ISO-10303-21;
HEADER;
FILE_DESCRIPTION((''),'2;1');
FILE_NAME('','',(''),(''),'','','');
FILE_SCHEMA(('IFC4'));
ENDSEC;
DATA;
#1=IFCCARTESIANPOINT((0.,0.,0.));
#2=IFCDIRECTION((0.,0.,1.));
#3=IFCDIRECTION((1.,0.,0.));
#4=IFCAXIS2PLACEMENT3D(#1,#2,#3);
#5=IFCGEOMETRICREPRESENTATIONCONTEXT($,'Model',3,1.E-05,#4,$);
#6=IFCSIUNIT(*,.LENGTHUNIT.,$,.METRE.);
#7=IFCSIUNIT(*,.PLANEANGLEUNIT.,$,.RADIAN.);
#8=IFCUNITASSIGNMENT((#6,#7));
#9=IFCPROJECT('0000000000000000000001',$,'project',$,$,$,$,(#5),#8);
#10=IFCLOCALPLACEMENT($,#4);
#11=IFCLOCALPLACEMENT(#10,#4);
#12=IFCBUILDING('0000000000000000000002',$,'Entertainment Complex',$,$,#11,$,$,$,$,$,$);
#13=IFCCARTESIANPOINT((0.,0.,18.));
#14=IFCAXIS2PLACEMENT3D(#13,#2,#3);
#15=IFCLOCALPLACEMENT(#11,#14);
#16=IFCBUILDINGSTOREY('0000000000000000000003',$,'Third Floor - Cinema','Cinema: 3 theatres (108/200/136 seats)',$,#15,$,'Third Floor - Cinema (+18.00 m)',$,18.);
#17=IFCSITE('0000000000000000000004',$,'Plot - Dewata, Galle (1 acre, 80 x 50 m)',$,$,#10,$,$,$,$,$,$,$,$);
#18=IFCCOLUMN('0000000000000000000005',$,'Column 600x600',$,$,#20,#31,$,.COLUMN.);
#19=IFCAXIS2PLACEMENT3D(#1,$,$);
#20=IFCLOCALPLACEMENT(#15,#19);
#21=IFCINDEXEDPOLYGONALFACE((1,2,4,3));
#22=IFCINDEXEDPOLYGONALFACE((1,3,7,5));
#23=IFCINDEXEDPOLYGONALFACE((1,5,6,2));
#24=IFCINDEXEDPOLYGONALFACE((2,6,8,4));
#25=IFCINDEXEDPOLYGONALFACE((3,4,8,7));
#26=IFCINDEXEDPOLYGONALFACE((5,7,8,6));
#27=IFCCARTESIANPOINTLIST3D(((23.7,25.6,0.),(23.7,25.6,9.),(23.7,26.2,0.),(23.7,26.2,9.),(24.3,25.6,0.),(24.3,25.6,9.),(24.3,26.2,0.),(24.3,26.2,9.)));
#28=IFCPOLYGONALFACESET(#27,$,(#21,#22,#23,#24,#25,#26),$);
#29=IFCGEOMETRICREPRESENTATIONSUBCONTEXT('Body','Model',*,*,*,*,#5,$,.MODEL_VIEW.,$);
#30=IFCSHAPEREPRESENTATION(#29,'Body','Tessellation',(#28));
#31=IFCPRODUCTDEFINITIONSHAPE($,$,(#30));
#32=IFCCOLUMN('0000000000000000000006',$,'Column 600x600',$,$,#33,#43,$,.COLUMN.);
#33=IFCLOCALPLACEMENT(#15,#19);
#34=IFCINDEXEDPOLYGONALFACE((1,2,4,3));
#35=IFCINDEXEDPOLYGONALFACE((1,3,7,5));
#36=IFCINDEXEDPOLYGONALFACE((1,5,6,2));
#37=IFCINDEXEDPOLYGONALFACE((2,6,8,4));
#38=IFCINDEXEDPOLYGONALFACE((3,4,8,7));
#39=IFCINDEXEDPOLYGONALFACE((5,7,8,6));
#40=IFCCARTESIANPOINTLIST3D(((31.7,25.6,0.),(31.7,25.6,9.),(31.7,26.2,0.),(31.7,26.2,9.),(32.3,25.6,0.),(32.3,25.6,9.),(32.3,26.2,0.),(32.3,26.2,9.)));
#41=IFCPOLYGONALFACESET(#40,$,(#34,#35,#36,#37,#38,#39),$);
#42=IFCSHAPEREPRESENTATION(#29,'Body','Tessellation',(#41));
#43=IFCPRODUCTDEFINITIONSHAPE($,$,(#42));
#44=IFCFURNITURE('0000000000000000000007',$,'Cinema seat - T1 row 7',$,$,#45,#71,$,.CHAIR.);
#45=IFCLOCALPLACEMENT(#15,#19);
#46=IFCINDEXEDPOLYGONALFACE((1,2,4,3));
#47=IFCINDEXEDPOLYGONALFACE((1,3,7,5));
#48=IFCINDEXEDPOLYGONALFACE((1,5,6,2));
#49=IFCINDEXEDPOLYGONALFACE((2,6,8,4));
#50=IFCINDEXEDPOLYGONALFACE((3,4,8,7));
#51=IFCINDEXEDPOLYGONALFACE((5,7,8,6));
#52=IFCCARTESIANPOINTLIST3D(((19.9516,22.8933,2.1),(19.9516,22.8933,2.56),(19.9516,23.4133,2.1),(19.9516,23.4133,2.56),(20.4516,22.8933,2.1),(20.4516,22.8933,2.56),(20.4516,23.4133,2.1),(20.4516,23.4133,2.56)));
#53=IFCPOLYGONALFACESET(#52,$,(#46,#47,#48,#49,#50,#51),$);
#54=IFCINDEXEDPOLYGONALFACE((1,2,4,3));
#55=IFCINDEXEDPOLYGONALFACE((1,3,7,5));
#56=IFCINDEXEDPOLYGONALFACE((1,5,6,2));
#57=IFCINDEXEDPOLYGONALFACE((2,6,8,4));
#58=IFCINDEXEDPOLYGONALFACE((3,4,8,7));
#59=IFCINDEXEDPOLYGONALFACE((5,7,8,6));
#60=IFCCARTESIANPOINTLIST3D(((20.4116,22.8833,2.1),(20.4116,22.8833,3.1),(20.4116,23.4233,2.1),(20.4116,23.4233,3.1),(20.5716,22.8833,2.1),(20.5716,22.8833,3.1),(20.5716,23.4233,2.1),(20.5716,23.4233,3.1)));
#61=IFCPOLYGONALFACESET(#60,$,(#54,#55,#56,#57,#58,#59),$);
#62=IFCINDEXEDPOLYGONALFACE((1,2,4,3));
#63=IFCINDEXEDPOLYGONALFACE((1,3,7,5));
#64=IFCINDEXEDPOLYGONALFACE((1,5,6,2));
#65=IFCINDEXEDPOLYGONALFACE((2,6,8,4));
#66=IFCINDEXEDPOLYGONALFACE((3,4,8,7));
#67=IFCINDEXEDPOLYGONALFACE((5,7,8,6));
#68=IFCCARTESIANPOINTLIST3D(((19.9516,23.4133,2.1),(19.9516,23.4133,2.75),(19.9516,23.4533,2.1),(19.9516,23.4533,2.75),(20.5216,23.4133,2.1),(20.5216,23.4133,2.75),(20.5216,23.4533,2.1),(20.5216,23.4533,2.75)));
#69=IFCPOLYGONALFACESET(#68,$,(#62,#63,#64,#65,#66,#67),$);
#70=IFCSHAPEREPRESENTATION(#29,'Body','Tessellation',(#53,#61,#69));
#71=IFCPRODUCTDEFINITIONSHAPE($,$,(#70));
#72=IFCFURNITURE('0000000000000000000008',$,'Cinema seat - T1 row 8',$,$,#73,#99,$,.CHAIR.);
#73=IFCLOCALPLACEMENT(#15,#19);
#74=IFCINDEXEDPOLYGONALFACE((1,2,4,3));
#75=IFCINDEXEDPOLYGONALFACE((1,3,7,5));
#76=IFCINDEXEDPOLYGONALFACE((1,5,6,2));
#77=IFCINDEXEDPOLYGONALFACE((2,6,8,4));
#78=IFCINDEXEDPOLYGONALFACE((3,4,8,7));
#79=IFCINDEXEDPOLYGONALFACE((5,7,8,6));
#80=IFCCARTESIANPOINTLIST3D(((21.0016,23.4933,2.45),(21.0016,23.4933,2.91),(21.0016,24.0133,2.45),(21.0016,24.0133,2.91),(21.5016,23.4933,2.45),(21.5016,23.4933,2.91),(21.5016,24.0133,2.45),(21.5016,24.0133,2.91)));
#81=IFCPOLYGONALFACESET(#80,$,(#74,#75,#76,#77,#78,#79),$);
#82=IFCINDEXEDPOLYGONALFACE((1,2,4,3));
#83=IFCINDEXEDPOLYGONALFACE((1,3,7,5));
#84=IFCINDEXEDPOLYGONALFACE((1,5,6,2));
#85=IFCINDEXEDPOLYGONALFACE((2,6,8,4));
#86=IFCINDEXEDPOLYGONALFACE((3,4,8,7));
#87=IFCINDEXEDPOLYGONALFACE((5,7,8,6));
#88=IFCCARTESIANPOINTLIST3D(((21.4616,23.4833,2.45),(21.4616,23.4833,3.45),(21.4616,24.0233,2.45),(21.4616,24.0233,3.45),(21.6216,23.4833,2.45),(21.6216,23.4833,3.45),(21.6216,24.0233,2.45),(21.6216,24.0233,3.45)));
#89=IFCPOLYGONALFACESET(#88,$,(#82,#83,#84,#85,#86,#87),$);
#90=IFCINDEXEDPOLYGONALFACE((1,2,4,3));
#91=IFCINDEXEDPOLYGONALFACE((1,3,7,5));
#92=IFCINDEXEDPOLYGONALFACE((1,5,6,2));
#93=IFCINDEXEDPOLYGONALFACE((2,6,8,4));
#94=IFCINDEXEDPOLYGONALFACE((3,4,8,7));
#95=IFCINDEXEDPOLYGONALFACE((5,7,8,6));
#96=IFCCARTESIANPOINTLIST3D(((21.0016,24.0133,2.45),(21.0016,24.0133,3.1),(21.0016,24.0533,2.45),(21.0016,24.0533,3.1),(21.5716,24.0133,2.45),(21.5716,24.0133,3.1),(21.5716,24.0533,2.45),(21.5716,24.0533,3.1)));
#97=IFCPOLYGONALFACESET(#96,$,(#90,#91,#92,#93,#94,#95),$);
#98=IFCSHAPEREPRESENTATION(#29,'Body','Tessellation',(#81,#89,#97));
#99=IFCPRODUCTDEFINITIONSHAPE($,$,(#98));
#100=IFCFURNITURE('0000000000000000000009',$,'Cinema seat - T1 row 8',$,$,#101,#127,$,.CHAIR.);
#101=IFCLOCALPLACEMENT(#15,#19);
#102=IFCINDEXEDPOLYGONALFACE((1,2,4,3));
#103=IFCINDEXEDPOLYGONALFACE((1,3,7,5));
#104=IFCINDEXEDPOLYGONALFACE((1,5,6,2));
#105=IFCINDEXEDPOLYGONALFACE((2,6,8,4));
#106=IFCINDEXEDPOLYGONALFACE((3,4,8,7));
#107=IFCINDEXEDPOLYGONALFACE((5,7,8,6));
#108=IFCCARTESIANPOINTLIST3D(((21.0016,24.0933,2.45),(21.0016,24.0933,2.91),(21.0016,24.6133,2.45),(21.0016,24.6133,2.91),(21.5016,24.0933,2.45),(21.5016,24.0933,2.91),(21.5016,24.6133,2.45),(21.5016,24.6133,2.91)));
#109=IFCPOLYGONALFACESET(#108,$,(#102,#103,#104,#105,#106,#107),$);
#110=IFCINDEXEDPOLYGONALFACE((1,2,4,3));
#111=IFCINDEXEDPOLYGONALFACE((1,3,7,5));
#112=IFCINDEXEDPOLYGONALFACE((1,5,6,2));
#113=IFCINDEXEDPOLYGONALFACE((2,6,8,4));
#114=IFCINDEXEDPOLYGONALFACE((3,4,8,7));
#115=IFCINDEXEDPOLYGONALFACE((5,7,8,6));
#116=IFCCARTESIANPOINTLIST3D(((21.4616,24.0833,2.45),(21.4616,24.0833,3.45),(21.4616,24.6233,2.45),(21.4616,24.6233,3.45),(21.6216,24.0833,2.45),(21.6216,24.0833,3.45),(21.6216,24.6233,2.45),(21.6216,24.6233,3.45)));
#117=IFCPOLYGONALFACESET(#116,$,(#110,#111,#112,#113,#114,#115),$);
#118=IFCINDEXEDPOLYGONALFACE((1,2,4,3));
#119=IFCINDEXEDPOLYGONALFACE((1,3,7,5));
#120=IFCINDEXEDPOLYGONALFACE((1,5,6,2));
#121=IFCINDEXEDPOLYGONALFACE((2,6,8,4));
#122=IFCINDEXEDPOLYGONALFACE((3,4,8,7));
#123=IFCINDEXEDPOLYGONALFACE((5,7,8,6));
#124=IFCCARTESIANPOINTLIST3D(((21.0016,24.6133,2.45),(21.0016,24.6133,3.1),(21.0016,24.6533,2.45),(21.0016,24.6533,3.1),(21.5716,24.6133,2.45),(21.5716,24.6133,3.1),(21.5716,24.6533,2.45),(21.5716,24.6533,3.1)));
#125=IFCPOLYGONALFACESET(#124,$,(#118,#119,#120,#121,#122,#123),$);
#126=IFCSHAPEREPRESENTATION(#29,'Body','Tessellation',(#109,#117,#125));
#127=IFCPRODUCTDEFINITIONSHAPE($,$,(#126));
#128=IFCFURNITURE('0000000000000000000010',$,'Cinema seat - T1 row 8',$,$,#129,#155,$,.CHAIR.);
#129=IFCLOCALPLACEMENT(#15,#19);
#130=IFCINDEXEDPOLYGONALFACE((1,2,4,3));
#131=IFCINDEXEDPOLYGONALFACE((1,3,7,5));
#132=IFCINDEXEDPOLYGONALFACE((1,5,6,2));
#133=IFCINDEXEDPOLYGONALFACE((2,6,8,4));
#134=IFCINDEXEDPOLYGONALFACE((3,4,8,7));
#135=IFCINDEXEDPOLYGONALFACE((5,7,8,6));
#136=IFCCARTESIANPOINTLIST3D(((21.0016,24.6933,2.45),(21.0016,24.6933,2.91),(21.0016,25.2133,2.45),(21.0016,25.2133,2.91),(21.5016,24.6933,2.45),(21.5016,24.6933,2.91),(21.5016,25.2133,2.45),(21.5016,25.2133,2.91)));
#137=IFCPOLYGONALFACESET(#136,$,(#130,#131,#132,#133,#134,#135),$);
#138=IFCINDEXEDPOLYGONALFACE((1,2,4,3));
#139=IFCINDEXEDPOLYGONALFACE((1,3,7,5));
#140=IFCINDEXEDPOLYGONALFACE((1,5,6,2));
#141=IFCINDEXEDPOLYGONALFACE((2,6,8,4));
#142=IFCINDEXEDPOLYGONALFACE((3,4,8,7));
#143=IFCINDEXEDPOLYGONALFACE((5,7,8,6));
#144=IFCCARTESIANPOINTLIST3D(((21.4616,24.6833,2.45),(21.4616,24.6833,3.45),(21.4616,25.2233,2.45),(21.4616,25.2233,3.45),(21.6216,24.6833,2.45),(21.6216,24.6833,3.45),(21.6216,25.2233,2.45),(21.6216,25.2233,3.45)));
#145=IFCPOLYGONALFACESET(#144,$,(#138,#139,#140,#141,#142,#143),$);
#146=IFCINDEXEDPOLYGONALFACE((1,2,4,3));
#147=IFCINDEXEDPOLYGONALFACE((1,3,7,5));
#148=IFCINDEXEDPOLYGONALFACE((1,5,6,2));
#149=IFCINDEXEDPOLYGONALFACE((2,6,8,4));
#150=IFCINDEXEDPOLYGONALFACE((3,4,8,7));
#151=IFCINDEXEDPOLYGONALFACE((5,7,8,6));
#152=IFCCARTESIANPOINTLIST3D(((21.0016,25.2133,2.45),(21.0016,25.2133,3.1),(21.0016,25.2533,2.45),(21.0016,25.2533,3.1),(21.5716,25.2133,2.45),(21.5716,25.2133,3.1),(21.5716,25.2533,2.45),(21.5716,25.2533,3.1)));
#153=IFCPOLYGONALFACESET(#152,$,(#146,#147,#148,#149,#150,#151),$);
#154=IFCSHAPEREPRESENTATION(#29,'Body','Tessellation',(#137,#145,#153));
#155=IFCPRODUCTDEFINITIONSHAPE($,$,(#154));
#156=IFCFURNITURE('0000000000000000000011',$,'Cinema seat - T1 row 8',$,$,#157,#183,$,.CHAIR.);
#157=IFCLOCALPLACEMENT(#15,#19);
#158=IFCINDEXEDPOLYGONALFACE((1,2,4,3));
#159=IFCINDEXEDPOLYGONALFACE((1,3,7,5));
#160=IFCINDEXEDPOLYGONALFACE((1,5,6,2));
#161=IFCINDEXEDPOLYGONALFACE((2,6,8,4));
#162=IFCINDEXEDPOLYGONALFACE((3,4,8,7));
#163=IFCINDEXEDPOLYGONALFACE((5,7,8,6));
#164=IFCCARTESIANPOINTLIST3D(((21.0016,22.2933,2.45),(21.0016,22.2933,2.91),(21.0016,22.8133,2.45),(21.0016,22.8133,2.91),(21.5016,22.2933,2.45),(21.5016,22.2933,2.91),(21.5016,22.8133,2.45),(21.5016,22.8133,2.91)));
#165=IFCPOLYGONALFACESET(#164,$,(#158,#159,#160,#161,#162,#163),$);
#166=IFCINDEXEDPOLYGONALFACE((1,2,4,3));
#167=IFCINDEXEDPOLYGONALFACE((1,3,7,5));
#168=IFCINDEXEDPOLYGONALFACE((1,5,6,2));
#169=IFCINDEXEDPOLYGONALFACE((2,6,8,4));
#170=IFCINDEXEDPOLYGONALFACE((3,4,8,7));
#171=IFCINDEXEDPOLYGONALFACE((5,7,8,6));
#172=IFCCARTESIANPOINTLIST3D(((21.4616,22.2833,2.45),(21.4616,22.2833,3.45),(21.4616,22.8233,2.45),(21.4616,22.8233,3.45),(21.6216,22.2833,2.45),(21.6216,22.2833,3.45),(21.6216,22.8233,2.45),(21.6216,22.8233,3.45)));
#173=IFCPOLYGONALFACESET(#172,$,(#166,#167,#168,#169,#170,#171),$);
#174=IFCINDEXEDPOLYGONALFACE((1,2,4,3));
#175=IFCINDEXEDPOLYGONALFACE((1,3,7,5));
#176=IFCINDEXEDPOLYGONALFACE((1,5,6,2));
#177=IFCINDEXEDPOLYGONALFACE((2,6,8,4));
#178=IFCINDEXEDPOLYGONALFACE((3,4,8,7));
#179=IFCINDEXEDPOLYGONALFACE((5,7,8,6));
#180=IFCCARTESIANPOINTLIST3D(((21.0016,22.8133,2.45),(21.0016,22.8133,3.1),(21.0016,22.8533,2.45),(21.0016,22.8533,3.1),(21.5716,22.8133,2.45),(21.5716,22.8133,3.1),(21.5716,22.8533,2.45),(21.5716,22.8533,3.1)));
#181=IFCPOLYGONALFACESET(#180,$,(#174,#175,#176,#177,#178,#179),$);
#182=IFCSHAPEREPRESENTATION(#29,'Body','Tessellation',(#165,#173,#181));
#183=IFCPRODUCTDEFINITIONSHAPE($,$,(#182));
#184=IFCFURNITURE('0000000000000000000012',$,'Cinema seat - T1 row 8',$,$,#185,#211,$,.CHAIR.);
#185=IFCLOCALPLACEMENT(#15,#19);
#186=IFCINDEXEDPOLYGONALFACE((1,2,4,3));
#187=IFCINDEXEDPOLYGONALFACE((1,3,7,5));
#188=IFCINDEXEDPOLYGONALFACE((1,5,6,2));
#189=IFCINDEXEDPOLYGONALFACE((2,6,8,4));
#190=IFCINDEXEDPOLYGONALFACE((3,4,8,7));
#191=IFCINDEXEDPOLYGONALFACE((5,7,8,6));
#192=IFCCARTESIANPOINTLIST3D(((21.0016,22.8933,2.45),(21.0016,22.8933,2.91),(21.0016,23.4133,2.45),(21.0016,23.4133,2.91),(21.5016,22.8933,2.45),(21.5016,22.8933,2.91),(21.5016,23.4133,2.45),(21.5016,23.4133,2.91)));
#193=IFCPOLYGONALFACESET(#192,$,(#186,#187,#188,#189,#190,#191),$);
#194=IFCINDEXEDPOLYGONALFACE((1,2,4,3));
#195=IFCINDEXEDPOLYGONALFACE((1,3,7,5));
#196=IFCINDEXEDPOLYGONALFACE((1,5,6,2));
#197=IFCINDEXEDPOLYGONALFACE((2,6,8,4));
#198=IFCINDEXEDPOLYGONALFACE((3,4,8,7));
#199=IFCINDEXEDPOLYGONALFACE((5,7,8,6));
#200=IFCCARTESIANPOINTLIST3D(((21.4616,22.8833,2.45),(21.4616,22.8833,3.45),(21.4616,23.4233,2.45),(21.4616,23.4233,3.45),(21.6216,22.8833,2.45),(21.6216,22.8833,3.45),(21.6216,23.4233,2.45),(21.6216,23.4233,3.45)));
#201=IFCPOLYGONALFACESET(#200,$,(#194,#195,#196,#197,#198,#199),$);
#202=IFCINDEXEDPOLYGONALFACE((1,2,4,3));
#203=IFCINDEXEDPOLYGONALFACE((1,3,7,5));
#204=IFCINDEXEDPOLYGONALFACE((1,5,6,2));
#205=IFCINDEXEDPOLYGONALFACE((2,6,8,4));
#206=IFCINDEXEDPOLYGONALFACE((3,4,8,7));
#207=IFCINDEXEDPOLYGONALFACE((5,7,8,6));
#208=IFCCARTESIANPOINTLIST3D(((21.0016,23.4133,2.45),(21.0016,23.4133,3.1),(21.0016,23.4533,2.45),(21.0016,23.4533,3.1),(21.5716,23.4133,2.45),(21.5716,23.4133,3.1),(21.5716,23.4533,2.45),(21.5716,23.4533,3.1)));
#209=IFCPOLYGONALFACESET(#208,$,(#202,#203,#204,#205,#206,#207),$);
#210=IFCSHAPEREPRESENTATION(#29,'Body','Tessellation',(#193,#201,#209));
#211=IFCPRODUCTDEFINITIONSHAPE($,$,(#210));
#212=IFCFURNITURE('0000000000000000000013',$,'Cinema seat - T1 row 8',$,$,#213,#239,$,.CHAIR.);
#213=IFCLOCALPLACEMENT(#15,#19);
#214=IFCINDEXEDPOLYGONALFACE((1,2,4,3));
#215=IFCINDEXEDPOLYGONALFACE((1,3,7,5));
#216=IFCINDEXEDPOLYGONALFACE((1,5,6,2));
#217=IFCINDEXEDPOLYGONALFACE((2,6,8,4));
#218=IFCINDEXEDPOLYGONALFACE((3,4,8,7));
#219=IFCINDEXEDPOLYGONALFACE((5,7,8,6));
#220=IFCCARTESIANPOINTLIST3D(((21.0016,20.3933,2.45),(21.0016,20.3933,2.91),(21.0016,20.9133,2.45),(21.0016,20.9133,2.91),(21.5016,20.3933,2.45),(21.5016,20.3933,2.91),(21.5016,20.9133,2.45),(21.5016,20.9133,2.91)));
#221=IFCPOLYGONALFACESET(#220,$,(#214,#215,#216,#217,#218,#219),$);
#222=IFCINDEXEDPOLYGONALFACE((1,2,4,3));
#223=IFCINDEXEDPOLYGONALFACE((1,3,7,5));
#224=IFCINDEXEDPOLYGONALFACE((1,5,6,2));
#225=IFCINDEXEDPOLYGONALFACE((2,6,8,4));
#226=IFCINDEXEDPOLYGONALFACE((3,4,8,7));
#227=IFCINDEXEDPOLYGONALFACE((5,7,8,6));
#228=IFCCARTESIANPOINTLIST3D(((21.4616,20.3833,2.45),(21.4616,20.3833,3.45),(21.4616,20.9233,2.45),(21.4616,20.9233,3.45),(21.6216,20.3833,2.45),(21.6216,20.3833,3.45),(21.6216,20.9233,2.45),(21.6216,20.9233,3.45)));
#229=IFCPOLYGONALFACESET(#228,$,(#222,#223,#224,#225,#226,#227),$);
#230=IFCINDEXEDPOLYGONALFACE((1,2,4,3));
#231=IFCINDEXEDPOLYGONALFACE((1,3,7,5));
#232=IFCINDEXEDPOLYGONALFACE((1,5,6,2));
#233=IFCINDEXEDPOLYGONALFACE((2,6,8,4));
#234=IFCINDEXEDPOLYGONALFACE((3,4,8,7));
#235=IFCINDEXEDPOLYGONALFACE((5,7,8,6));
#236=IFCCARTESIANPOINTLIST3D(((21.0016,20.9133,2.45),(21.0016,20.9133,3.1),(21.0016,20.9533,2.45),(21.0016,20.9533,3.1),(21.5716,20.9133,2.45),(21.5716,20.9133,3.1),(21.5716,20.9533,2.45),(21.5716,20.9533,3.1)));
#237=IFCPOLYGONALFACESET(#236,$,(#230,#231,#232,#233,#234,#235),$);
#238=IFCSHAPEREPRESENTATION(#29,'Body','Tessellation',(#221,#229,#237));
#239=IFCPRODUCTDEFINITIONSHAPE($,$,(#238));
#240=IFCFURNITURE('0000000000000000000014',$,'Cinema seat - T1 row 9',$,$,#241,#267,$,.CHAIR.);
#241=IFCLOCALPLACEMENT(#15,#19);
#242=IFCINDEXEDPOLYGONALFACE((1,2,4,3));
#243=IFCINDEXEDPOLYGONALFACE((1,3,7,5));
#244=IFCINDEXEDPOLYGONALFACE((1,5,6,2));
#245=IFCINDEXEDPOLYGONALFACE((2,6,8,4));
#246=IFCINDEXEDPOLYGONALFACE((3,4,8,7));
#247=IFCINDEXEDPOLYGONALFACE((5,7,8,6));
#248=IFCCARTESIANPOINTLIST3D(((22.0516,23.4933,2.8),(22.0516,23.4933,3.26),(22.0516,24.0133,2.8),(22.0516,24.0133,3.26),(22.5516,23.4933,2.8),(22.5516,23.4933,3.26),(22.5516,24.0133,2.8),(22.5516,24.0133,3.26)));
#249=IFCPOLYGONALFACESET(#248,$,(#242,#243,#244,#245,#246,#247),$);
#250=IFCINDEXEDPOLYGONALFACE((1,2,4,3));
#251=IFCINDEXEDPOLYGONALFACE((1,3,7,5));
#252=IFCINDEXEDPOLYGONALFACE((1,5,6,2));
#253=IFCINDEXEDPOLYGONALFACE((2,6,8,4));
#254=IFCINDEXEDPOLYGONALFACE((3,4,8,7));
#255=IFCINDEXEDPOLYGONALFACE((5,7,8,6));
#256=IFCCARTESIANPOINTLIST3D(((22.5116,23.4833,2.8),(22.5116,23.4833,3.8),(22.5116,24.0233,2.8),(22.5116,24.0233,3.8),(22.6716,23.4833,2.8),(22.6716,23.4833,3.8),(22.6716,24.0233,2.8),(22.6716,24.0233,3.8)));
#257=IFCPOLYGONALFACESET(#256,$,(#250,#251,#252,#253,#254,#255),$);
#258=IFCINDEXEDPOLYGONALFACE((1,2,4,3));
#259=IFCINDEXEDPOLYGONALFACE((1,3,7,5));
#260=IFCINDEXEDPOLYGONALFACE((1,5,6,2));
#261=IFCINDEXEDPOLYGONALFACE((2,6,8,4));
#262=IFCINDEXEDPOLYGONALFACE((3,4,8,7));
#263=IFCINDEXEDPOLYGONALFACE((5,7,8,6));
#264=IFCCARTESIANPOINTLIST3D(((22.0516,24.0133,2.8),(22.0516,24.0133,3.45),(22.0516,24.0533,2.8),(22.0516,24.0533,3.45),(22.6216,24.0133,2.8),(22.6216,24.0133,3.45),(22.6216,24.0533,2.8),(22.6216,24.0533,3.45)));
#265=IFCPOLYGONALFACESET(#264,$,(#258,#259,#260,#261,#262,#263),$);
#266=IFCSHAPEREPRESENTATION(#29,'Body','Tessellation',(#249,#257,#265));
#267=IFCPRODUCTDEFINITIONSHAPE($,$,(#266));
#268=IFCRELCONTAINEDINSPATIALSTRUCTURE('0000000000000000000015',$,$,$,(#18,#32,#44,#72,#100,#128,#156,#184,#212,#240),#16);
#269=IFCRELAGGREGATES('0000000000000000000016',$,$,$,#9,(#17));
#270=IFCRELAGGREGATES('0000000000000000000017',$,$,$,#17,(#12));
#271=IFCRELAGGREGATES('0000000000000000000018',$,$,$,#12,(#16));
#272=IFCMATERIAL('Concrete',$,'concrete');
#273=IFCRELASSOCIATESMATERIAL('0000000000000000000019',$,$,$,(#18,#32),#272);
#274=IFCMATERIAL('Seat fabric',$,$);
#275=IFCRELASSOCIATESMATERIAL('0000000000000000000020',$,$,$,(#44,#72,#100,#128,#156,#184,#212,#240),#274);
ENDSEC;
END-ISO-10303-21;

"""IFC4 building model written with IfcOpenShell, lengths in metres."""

from ifc_helpers import new_model, si_unit, frame, origin_with_axes, place, context, subcontext, project, spatial, polyline, outline, extrude, material, element, save


model = new_model("IFC4")

# Units and contexts
model_context = context("Model", 3, precision=1e-05, world=origin_with_axes())
body_context = subcontext(model_context, "Body", "Model", "MODEL_VIEW")
ifc_project = project(units=[si_unit("LENGTHUNIT", "METRE"), si_unit("PLANEANGLEUNIT", "RADIAN")], contexts=[model_context])

# Site, building, storey
site_placement = place(None, origin_with_axes())
site = spatial("IfcSite", under=ifc_project, at=site_placement, Name="Plot - Dewata, Galle (1 acre, 80 x 50 m)")
building_placement = place(site_placement, origin_with_axes())
building = spatial("IfcBuilding", under=site, at=building_placement, Name="Entertainment Complex")
storey_placement = place(building_placement, frame((0.0, 0.0, 18.0), z_axis=(0.0, 0.0, 1.0), x_axis=(1.0, 0.0, 0.0)))
storey = spatial("IfcBuildingStorey", under=building, at=storey_placement, Name="Third Floor - Cinema", Description="Cinema: 3 theatres (108/200/136 seats)", LongName="Third Floor - Cinema (+18.00 m)", Elevation=18.0)

# Columns
ifc_material_1 = material(Name="Concrete", Category="concrete")
for number, where, z_axis, x_axis, name in (
    (1, (24.0, 25.9, 0.0), (0.0, 0.0, 1.0), (1.0, 0.0, 0.0), "Column 600x600"),
    (2, (32.0, 25.9, 0.0), (0.0, 0.0, 1.0), (1.0, 0.0, 0.0), "Column 600x600"),
):
    element("IfcColumn", number, at=place(storey_placement, frame(where, z_axis=z_axis, x_axis=x_axis)), inside=storey, material=ifc_material_1, Name=name, PredefinedType="COLUMN", context=body_context, shape_type="SweptSolid", body=[
        extrude(outline(polyline([(-0.3, -0.3), (0.3, -0.3), (0.3, 0.3), (-0.3, 0.3), (-0.3, -0.3)])), origin_with_axes(), (0.0, 0.0, 1.0), 9.0),
    ])

# Furniture
ifc_material_2 = material(Name="Seat fabric")
for number, where, z_axis, x_axis, name in (
    (3, (20.5716, 23.1533, 2.1), (0.0, 0.0, 1.0), (1.0, 0.0, 0.0), "Cinema seat - T1 row 7"),
    (4, (21.6216, 23.7533, 2.45), (0.0, 0.0, 1.0), (1.0, 0.0, 0.0), "Cinema seat - T1 row 8"),
    (5, (21.6216, 24.3533, 2.45), (0.0, 0.0, 1.0), (1.0, 0.0, 0.0), "Cinema seat - T1 row 8"),
    (6, (21.6216, 24.9533, 2.45), (0.0, 0.0, 1.0), (1.0, 0.0, 0.0), "Cinema seat - T1 row 8"),
    (7, (21.6216, 22.5533, 2.45), (0.0, 0.0, 1.0), (1.0, 0.0, 0.0), "Cinema seat - T1 row 8"),
    (8, (21.6216, 23.1533, 2.45), (0.0, 0.0, 1.0), (1.0, 0.0, 0.0), "Cinema seat - T1 row 8"),
    (9, (21.6216, 20.6533, 2.45), (0.0, 0.0, 1.0), (1.0, 0.0, 0.0), "Cinema seat - T1 row 8"),
    (10, (22.6716, 23.7533, 2.8), (0.0, 0.0, 1.0), (1.0, 0.0, 0.0), "Cinema seat - T1 row 9"),
):
    element("IfcFurniture", number, at=place(storey_placement, frame(where, z_axis=z_axis, x_axis=x_axis)), inside=storey, material=ifc_material_2, Name=name, PredefinedType="CHAIR", context=body_context, shape_type="SweptSolid", body=[
        extrude(outline(polyline([(-0.62, -0.26), (-0.12, -0.26), (-0.12, 0.26), (-0.62, 0.26), (-0.62, -0.26)])), origin_with_axes(), (0.0, 0.0, 1.0), 0.46),
        extrude(outline(polyline([(-0.16, -0.27), (0.0, -0.27), (0.0, 0.27), (-0.16, 0.27), (-0.16, -0.27)])), origin_with_axes(), (0.0, 0.0, 1.0), 1.0),
        extrude(outline(polyline([(-0.62, 0.26), (-0.05, 0.26), (-0.05, 0.3), (-0.62, 0.3), (-0.62, 0.26)])), origin_with_axes(), (0.0, 0.0, 1.0), 0.65),
    ])

save(model, "model.ifc")
